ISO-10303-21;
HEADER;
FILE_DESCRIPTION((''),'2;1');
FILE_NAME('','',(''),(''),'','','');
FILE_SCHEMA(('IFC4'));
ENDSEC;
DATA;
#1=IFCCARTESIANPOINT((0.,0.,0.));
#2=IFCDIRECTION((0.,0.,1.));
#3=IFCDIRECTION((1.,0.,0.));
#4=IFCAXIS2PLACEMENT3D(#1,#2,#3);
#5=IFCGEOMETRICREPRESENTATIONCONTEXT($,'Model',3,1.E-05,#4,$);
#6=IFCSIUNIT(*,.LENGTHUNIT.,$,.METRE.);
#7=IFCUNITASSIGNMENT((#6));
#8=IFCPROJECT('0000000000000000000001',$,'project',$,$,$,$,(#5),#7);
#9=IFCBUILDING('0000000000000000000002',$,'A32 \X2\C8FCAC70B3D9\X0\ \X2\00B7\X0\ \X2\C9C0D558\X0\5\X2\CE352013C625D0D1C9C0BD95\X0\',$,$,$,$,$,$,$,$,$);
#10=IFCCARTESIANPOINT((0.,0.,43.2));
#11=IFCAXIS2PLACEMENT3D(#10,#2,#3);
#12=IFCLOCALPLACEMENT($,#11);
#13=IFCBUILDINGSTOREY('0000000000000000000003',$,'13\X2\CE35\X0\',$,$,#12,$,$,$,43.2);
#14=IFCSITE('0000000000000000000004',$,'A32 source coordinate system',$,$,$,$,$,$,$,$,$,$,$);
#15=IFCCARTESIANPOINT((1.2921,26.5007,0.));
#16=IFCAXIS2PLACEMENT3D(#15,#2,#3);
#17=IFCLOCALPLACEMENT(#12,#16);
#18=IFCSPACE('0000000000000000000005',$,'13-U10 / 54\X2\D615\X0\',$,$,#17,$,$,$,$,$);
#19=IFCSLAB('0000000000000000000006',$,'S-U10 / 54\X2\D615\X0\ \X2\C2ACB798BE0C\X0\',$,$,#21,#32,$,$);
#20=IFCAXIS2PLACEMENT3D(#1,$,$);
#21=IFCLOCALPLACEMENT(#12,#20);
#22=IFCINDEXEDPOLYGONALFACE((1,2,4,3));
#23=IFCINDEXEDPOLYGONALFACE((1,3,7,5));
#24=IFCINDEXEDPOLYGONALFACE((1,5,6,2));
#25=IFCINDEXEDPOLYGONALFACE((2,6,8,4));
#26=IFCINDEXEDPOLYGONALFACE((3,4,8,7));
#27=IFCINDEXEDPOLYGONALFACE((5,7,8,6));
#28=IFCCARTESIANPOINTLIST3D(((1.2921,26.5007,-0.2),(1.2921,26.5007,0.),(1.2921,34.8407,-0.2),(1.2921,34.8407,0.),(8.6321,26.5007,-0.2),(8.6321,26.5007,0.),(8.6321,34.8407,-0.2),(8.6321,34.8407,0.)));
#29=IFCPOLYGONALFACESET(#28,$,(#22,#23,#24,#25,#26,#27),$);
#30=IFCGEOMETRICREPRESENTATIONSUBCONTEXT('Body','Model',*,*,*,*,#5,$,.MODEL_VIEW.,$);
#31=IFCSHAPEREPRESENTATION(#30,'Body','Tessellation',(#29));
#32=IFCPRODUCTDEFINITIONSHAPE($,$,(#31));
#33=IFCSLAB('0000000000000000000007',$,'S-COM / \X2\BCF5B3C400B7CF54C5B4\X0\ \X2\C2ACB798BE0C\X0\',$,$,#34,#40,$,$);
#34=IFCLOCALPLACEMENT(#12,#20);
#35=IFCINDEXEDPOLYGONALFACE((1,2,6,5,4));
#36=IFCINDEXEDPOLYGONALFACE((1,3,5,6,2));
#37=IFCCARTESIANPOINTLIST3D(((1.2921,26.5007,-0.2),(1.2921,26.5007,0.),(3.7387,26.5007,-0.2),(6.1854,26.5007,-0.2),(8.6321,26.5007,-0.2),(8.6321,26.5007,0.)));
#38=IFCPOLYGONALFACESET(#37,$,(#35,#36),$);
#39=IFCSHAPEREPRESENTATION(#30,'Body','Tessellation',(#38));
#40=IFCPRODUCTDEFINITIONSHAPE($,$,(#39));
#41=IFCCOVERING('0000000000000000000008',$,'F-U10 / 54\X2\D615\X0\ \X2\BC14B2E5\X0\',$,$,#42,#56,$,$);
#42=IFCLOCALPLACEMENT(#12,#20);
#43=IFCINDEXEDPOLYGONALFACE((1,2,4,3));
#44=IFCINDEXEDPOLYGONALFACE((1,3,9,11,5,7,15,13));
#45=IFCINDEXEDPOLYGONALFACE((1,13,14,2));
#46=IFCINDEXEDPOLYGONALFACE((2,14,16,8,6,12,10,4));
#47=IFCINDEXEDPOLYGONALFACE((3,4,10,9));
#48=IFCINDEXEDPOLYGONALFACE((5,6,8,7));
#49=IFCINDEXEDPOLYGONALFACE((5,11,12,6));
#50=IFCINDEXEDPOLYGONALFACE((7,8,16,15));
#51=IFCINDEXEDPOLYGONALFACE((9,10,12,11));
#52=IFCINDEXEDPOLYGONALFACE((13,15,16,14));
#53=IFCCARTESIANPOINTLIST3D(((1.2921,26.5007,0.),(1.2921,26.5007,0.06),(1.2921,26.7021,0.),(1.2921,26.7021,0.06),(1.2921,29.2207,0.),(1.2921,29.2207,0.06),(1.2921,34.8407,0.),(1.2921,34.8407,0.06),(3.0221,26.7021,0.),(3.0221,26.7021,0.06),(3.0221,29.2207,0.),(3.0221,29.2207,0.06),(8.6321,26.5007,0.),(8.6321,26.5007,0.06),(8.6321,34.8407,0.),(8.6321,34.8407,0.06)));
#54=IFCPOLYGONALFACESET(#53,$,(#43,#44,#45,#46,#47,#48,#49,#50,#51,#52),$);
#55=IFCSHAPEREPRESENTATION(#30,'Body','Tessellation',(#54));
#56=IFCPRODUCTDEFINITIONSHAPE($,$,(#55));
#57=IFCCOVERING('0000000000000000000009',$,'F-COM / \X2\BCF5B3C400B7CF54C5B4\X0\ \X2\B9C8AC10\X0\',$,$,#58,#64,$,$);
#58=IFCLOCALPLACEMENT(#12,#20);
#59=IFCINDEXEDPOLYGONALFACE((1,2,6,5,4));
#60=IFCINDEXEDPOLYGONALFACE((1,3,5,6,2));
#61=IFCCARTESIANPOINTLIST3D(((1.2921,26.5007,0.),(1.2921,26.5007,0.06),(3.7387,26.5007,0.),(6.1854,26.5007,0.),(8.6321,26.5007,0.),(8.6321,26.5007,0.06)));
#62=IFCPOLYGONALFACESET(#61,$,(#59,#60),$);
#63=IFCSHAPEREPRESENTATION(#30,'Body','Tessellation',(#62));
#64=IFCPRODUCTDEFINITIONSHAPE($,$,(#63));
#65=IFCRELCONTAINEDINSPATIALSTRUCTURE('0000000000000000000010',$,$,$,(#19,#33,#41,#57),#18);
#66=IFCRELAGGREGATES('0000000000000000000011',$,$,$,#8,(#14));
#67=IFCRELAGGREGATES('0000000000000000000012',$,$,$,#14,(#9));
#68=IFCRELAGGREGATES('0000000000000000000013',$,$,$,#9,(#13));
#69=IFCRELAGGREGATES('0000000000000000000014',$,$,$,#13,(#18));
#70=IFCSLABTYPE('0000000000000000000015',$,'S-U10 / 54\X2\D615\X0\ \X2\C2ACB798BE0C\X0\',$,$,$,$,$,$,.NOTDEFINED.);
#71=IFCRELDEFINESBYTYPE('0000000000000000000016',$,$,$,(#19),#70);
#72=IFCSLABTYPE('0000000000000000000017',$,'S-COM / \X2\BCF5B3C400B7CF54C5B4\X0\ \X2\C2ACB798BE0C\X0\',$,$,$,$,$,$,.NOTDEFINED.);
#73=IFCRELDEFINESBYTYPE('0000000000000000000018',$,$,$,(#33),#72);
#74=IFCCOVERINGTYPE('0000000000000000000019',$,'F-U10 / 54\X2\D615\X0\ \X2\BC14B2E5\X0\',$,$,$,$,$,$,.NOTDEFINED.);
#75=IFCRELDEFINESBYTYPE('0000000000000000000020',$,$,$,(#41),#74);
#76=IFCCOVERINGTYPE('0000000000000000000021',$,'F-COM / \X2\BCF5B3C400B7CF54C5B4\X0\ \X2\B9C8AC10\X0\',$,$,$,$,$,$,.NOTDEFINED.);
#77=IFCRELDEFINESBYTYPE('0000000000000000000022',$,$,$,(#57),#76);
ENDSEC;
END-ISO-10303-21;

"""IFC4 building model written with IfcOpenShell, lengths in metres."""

from ifc_helpers import new_model, si_unit, frame, origin, origin_with_axes, place, context, subcontext, project, spatial, polyline, outline, extrude, source, transform, mapped, type_object, type_shapes, element, save


model = new_model("IFC4")

# Units and contexts
model_context = context("Model", 3, precision=1e-05, world=origin_with_axes())
body_context = subcontext(model_context, "Body", "Model", "MODEL_VIEW")
ifc_project = project(units=[si_unit("LENGTHUNIT", "METRE")], contexts=[model_context])

# Site, building, storey, space
storey_placement = place(None, frame((0.0, 0.0, 43.2), z_axis=(0.0, 0.0, 1.0), x_axis=(1.0, 0.0, 0.0)))
space_placement = place(storey_placement, frame((1.2921, 26.5007, 0.0), z_axis=(0.0, 0.0, 1.0), x_axis=(1.0, 0.0, 0.0)))
site = spatial("IfcSite", under=ifc_project, Name="A32 source coordinate system")
building = spatial("IfcBuilding", under=site, Name="A32 주거동 · 지하5층–옥탑지붕")
storey = spatial("IfcBuildingStorey", under=building, at=storey_placement, Name="13층", Elevation=43.2)
space = spatial("IfcSpace", under=storey, at=space_placement, Name="13-U10 / 54형")

# Slabs
slab_type_1 = type_object("IfcSlabType", Name="S-U10 / 54형 슬래브", PredefinedType="NOTDEFINED")
shared_shape_1 = source(origin(), body_context, "Body", "SweptSolid", [
    extrude(outline(polyline([(0.0, 0.0), (0.0, 8.34), (7.34, 8.34), (7.34, 0.0), (0.0, 0.0)])), frame((0.0, 0.0, -0.2)), (0.0, 0.0, 1.0), 0.2),
])
type_shapes(slab_type_1, [shared_shape_1])
slab_1_placement = place(space_placement, origin_with_axes())
element("IfcSlab", 1, at=slab_1_placement, inside=space, type_object=slab_type_1, Name="S-U10 / 54형 슬래브", context=body_context, shape_type="MappedRepresentation", body=[
    mapped(shared_shape_1, transform((0.0, 0.0, 0.0), scale=1.0)),
])
slab_type_2 = type_object("IfcSlabType", Name="S-COM / 복도·코어 슬래브", PredefinedType="NOTDEFINED")
shared_shape_2 = source(origin(), body_context, "Body", "SweptSolid", [
    extrude(outline(polyline([(7.34, 0.0), (7.34, 0.0), (0.0, 0.0), (0.0, 0.0), (7.34, 0.0)])), frame((0.0, 0.0, -0.2)), (0.0, 0.0, 1.0), 0.2),
])
type_shapes(slab_type_2, [shared_shape_2])
slab_2_placement = place(space_placement, origin_with_axes())
element("IfcSlab", 2, at=slab_2_placement, inside=space, type_object=slab_type_2, Name="S-COM / 복도·코어 슬래브", context=body_context, shape_type="MappedRepresentation", body=[
    mapped(shared_shape_2, transform((0.0, 0.0, 0.0), scale=1.0)),
])

# Coverings
covering_type_1 = type_object("IfcCoveringType", Name="F-U10 / 54형 바닥", PredefinedType="NOTDEFINED")
shared_shape_3 = source(origin(), body_context, "Body", "SweptSolid", [
    extrude(outline(polyline([(7.34, 0.0), (0.0, 0.0), (0.0, 0.2014), (1.73, 0.2014), (1.73, 2.72), (0.0, 2.72), (0.0, 8.34), (7.34, 8.34), (7.34, 0.0)])), origin(), (0.0, 0.0, 1.0), 0.06),
])
type_shapes(covering_type_1, [shared_shape_3])
covering_1_placement = place(space_placement, origin_with_axes())
element("IfcCovering", 3, at=covering_1_placement, inside=space, type_object=covering_type_1, Name="F-U10 / 54형 바닥", context=body_context, shape_type="MappedRepresentation", body=[
    mapped(shared_shape_3, transform((0.0, 0.0, 0.0), scale=1.0)),
])
covering_type_2 = type_object("IfcCoveringType", Name="F-COM / 복도·코어 마감", PredefinedType="NOTDEFINED")
shared_shape_4 = source(origin(), body_context, "Body", "SweptSolid", [
    extrude(outline(polyline([(7.34, 0.0), (7.34, 0.0), (0.0, 0.0), (0.0, 0.0), (7.34, 0.0)])), origin(), (0.0, 0.0, 1.0), 0.06),
])
type_shapes(covering_type_2, [shared_shape_4])
covering_2_placement = place(space_placement, origin_with_axes())
element("IfcCovering", 4, at=covering_2_placement, inside=space, type_object=covering_type_2, Name="F-COM / 복도·코어 마감", context=body_context, shape_type="MappedRepresentation", body=[
    mapped(shared_shape_4, transform((0.0, 0.0, 0.0), scale=1.0)),
])

save(model, "model.ifc")
